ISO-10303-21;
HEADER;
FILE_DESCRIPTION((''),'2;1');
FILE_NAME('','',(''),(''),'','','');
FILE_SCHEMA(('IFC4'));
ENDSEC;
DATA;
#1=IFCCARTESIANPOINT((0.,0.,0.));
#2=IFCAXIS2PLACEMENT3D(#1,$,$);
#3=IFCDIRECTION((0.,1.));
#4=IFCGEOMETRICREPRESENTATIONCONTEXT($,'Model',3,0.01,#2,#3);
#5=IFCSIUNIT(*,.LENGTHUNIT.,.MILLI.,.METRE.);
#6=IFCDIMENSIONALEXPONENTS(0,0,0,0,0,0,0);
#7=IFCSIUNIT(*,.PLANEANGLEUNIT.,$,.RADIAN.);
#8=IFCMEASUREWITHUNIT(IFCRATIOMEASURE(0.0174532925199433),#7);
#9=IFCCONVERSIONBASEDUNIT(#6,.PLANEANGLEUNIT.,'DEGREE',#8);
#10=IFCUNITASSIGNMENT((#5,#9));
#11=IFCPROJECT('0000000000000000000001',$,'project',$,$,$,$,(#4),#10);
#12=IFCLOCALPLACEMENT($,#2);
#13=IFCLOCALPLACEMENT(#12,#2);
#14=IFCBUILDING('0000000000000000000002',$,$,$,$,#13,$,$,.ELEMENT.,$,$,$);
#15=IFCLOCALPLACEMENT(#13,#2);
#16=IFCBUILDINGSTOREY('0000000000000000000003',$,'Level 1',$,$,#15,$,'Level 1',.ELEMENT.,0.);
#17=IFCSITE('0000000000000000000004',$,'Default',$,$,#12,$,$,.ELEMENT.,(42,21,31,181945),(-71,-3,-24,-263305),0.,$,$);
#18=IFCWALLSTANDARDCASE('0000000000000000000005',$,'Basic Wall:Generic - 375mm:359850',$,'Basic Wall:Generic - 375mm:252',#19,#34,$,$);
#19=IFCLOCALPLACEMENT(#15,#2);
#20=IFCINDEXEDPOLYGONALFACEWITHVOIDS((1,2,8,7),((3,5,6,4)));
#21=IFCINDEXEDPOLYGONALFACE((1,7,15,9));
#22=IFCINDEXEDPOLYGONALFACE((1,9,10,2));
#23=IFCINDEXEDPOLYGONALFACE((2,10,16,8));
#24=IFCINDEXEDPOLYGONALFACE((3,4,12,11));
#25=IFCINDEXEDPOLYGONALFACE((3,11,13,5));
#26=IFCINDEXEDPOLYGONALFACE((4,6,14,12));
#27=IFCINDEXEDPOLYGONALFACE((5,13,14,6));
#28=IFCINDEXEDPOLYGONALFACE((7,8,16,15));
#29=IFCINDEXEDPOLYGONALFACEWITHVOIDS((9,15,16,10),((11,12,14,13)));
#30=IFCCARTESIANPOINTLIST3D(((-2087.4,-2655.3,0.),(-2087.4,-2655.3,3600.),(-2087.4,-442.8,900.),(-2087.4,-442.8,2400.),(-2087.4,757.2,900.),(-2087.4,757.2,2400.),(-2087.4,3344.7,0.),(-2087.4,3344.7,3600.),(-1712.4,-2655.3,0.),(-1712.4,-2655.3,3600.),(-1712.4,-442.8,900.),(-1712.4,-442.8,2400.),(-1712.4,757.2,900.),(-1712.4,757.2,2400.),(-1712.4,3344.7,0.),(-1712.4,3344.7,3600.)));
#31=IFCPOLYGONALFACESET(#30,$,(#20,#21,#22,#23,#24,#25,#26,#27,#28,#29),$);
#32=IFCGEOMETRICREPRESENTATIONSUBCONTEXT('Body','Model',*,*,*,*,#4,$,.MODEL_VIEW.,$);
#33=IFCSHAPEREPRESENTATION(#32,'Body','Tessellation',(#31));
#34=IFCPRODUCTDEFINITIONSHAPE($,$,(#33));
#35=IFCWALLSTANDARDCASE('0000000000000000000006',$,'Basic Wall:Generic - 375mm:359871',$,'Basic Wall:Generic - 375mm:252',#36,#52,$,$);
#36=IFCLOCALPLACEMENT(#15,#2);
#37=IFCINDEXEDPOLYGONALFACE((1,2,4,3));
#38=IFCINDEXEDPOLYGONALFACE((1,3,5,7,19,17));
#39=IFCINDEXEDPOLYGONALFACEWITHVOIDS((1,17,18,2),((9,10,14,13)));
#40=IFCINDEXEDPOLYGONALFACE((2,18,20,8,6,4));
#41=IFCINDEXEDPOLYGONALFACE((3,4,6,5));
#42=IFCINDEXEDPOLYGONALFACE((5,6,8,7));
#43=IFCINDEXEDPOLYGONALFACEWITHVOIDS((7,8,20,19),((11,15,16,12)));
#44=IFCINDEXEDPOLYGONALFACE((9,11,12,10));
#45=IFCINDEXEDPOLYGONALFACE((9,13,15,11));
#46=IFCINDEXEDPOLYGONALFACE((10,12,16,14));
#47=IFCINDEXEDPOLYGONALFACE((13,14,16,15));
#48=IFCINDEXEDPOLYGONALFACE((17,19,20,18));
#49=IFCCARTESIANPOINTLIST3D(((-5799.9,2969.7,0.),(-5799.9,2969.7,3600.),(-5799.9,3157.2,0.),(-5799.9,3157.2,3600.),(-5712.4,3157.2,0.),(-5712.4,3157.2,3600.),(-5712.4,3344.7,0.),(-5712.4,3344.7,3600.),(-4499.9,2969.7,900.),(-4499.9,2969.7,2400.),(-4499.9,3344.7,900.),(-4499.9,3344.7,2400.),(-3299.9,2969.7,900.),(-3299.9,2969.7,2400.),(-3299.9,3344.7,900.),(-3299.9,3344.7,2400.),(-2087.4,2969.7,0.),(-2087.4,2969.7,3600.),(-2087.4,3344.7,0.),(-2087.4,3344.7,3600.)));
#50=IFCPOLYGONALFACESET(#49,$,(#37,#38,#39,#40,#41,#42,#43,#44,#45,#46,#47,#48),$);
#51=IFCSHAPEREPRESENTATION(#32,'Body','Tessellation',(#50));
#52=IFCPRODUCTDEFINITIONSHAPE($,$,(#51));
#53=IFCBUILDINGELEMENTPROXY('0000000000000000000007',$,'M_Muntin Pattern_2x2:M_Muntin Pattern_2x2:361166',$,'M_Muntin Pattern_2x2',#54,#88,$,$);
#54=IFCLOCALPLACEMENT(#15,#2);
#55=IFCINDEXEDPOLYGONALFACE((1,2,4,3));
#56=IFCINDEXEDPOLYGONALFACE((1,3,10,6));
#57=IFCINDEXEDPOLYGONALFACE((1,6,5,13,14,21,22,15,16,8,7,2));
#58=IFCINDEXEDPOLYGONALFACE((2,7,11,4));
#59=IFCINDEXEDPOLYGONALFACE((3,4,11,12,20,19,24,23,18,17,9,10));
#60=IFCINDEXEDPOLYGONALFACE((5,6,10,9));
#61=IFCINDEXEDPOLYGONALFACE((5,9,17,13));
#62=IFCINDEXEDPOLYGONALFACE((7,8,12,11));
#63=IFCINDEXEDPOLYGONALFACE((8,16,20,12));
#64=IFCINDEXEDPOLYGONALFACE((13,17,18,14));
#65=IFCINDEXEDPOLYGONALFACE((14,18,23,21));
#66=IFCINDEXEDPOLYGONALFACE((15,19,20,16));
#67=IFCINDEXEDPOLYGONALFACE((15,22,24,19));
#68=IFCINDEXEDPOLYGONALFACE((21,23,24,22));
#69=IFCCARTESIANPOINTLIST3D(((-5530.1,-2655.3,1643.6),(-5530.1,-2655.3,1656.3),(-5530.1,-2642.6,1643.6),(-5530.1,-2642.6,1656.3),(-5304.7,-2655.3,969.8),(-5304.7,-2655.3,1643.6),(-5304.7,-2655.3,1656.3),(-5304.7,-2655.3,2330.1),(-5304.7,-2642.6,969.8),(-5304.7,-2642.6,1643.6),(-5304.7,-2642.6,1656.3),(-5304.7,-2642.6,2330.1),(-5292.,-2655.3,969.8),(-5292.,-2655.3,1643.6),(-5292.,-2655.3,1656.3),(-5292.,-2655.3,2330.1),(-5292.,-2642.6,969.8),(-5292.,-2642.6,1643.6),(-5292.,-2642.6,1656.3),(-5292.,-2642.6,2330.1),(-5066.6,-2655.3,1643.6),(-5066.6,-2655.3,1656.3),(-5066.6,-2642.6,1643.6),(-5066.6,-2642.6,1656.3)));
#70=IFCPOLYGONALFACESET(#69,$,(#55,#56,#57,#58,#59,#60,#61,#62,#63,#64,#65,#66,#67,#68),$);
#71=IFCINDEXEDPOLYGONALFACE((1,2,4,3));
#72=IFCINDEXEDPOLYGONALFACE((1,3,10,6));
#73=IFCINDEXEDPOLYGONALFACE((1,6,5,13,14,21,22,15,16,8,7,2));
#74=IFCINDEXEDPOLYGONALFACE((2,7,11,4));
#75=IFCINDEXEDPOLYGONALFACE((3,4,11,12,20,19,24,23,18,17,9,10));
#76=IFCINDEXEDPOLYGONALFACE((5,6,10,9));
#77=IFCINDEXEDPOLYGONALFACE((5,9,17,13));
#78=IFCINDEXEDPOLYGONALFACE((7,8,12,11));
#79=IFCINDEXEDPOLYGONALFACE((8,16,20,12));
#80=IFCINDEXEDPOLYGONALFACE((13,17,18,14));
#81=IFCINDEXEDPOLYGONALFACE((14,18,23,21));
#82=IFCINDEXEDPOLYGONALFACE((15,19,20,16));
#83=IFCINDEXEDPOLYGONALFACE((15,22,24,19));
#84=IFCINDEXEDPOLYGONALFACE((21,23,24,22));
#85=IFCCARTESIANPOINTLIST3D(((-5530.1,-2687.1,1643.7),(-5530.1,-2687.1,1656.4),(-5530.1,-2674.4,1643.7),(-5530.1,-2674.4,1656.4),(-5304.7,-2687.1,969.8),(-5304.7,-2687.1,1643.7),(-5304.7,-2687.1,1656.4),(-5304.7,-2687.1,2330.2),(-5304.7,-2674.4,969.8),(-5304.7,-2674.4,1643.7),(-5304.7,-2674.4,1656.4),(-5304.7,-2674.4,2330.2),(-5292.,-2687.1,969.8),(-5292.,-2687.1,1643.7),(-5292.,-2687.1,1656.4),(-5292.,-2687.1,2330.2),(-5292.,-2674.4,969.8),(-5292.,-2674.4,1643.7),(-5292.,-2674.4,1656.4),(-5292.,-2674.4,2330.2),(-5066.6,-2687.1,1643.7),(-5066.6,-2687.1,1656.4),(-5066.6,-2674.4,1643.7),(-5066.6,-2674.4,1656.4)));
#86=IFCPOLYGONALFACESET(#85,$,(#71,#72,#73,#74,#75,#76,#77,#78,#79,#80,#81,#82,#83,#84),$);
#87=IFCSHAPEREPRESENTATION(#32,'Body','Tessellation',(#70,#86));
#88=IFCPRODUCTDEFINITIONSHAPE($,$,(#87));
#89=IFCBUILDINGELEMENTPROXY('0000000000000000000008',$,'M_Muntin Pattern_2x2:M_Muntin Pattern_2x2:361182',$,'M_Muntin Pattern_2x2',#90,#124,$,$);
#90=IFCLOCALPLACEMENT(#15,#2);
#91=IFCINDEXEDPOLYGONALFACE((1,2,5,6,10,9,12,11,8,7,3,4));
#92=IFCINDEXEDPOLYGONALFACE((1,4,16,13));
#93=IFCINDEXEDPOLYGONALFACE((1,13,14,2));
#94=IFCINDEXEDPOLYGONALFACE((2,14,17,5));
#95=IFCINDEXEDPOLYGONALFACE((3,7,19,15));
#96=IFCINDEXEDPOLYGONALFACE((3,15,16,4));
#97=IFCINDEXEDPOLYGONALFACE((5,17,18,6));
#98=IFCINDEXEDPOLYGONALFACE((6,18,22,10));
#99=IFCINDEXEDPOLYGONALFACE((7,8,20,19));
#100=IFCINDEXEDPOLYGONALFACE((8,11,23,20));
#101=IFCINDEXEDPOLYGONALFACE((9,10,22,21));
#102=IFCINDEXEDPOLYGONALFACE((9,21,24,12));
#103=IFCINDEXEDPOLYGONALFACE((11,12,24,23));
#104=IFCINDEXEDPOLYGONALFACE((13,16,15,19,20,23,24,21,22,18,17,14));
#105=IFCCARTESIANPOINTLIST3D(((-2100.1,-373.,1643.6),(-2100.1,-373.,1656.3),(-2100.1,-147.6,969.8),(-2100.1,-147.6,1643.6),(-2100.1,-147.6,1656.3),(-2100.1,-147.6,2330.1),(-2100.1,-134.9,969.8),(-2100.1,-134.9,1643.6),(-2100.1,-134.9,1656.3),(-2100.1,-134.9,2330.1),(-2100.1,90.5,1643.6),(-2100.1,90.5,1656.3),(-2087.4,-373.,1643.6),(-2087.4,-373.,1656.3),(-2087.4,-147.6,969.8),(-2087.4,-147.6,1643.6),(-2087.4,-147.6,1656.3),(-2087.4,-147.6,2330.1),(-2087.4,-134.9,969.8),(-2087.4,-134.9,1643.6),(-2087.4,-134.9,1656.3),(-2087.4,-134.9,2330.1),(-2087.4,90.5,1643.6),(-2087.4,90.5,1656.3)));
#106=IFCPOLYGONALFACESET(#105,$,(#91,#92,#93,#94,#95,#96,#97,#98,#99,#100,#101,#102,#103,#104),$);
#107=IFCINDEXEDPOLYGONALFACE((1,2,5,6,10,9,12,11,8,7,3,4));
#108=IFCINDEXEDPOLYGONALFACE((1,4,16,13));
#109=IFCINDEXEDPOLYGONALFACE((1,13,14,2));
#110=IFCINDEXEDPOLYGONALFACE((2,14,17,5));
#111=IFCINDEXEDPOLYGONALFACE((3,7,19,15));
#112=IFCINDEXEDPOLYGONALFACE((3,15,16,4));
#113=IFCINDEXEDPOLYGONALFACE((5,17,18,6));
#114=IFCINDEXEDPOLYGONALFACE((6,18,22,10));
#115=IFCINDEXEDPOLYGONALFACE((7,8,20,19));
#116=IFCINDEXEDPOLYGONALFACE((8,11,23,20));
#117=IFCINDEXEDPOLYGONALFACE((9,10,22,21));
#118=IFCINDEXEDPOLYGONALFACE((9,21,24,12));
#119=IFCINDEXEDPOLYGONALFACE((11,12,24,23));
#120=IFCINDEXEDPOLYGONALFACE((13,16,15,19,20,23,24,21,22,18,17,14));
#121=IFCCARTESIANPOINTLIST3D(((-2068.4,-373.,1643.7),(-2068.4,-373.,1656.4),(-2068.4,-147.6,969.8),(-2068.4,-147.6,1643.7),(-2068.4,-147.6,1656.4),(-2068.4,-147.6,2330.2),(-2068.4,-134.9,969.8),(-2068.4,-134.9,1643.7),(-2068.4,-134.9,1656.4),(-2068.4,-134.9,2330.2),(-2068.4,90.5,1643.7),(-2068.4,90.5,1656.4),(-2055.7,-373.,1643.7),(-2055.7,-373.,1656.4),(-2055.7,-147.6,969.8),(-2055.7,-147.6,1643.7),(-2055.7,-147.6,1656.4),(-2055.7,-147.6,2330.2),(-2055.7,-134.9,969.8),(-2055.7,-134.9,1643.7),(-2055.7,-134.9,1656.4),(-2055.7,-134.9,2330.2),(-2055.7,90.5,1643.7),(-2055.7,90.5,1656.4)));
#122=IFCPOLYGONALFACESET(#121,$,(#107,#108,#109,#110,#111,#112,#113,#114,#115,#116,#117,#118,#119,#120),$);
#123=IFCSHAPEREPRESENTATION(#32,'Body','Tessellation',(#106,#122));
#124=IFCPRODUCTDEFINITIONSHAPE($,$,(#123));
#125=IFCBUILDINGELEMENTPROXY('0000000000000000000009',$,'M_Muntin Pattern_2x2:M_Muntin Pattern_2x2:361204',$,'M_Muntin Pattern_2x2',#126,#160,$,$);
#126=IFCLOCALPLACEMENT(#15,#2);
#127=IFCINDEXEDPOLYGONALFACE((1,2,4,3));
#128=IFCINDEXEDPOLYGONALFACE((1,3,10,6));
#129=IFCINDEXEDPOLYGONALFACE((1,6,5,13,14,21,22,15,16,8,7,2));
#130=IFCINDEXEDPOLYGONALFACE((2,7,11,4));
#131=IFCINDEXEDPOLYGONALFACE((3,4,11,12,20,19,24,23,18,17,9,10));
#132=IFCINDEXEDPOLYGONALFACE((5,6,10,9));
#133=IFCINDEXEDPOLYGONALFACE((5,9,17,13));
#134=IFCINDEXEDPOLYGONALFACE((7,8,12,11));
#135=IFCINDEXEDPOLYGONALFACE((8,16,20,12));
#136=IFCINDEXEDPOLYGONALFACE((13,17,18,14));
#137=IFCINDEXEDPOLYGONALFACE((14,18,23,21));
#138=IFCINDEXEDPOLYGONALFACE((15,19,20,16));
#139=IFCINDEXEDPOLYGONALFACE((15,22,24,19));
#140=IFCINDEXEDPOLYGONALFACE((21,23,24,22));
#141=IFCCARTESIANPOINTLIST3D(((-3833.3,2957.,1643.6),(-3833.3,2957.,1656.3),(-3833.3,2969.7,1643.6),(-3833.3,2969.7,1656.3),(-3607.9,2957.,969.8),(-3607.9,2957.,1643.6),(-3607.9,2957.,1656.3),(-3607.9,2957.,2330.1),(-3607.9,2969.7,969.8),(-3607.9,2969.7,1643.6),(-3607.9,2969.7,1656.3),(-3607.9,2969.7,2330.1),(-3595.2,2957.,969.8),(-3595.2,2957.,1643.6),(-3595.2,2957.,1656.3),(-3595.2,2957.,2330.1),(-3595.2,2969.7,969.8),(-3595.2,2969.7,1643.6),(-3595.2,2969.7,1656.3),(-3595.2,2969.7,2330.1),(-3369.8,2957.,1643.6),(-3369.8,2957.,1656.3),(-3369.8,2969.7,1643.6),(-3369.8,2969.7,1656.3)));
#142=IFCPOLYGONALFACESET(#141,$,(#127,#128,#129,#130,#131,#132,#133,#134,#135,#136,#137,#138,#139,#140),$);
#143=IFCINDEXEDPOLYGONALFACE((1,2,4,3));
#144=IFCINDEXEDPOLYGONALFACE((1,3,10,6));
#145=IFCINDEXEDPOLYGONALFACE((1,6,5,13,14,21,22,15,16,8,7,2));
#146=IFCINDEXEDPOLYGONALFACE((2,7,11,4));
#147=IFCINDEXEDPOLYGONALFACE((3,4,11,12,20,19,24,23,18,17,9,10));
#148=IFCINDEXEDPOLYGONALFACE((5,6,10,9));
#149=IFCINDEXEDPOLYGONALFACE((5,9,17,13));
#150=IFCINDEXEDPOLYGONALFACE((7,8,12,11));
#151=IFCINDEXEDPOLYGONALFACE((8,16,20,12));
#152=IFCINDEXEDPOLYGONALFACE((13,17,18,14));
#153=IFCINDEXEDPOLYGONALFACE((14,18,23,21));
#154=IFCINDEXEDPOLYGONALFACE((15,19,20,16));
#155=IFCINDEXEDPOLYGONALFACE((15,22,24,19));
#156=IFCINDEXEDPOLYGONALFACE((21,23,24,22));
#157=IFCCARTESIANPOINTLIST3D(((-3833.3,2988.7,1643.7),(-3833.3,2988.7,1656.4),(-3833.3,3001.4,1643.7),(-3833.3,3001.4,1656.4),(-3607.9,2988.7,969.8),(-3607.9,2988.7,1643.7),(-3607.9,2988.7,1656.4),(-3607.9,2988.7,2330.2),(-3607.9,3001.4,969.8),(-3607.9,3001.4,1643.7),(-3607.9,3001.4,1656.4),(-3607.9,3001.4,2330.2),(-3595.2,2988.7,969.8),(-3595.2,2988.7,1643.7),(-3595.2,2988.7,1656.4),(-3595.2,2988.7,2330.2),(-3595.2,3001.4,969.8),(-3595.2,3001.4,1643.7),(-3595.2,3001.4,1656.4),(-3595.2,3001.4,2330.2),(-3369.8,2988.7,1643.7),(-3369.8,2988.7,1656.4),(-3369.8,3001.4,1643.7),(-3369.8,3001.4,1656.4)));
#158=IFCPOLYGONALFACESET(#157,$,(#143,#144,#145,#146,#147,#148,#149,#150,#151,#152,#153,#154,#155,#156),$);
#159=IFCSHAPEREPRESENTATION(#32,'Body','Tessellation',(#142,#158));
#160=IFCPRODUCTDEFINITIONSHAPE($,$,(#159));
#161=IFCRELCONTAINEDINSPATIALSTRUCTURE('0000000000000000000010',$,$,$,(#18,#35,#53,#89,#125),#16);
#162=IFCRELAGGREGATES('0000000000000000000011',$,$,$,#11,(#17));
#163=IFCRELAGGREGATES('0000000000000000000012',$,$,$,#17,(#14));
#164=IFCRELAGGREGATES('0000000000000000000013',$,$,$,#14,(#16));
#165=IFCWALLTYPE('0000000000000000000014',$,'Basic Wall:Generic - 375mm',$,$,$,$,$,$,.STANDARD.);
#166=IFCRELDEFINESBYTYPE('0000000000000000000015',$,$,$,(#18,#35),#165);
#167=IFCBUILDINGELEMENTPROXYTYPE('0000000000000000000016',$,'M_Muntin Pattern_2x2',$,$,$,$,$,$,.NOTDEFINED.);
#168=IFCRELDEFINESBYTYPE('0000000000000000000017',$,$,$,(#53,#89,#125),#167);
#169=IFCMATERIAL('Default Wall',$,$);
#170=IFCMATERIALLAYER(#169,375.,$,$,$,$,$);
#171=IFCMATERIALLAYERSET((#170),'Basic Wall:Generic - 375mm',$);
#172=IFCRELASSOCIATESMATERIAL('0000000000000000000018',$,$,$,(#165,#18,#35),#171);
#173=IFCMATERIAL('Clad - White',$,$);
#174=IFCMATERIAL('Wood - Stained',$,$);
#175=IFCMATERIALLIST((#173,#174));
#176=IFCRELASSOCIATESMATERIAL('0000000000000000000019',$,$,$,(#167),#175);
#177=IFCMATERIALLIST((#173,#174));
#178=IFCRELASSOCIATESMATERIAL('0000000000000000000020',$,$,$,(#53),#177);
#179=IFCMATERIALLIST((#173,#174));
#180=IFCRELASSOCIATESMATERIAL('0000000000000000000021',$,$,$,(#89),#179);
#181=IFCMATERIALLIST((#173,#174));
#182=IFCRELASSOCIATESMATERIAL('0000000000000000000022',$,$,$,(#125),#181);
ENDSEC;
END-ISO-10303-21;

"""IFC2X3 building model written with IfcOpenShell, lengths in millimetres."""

from ifc_helpers import new_model, entity, si_unit, converted_unit, direction, frame, frame_2d, origin, place, context, subcontext, project, spatial, polyline, rectangle, outline, extrude, clip, bounded_halfspace, source, transform, mapped, material, material_list, layer, layer_set, layer_usage, type_object, type_shapes, element, save


model = new_model("IFC2X3")

# Units and contexts
model_context = context("Model", 3, precision=0.01, world=origin(), true_north=direction((0.0, 1.0)))
body_context = subcontext(model_context, "Body", "Model", "MODEL_VIEW")
ifc_project = project(units=[si_unit("LENGTHUNIT", "METRE", prefix="MILLI"), converted_unit("PLANEANGLEUNIT", "DEGREE", entity("IfcRatioMeasure", 0.0174532925199433), si_unit("PLANEANGLEUNIT", "RADIAN"), dimensions=[0, 0, 0, 0, 0, 0, 0])], contexts=[model_context])

# Site, building, storey
site_placement = place(None, origin())
site = spatial("IfcSite", under=ifc_project, at=site_placement, Name="Default", CompositionType="ELEMENT", RefLatitude=(42, 21, 31, 181945), RefLongitude=(-71, -3, -24, -263305), RefElevation=0.0)
building_placement = place(site_placement, origin())
building = spatial("IfcBuilding", under=site, at=building_placement, CompositionType="ELEMENT")
storey_placement = place(building_placement, origin())
storey = spatial("IfcBuildingStorey", under=building, at=storey_placement, Name="Level 1", LongName="Level 1", CompositionType="ELEMENT", Elevation=0.0)

# Walls, openings
ifc_material_1 = material(Name="Default Wall")
ifc_layer = layer(ifc_material_1, 375.0)
ifc_layer_set = layer_set([ifc_layer], Name="Basic Wall:Generic - 375mm")
ifc_layer_usage_1 = layer_usage(ifc_layer_set, "AXIS2", "NEGATIVE", 187.5)
wall_type = type_object("IfcWallType", Name="Basic Wall:Generic - 375mm", PredefinedType="STANDARD", material=ifc_layer_set)
wall_1_placement = place(storey_placement, frame((-1899.9, -2655.3, 0.0), z_axis=(0.0, 0.0, 1.0), x_axis=(0.0, 1.0, 0.0)))
wall_1 = element("IfcWallStandardCase", 1, at=wall_1_placement, inside=storey, type_object=wall_type, material=ifc_layer_usage_1, Name="Basic Wall:Generic - 375mm:359850", ObjectType="Basic Wall:Generic - 375mm:252", context=body_context, shape_type="Clipping", body=[
    clip(extrude(rectangle(XDim=6000.0, YDim=375.0, at=frame_2d((3000.0, 0.0), x_axis=(-1.0, 0.0))), origin(), (0.0, 0.0, 1.0), 3600.0), bounded_halfspace(frame((0.0, -187.5, 3600.0), z_axis=(0.0, 0.0, -1.0), x_axis=(0.0, -1.0, 0.0)), True, frame((0.0, -187.5, 3600.0)), polyline([(0.0, 0.0), (6000.0, 0.0), (6000.0, 375.0), (5625.0, 375.0), (0.0, 375.0), (0.0, 0.0)]))),
])
opening_1_placement = place(wall_1_placement, frame((2212.5, -187.5, 900.0)))
element("IfcOpeningElement", 2, at=opening_1_placement, cuts=wall_1, ObjectType="Opening", context=body_context, shape_type="SweptSolid", body=[
    extrude(rectangle(XDim=1500.0, YDim=1200.0, at=frame_2d((750.0, 600.0), x_axis=(-1.0, 0.0))), frame((0.0, 0.0, 0.0), z_axis=(0.0, 1.0, 0.0), x_axis=(0.0, 0.0, 1.0)), (0.0, 0.0, 1.0), 375.0),
])
ifc_layer_usage_2 = layer_usage(ifc_layer_set, "AXIS2", "NEGATIVE", 187.5)
wall_2_placement = place(storey_placement, frame((-2087.4, 3157.2, 0.0), z_axis=(0.0, 0.0, 1.0), x_axis=(-1.0, 0.0, 0.0)))
wall_2 = element("IfcWallStandardCase", 3, at=wall_2_placement, inside=storey, type_object=wall_type, material=ifc_layer_usage_2, Name="Basic Wall:Generic - 375mm:359871", ObjectType="Basic Wall:Generic - 375mm:252", context=body_context, shape_type="Clipping", body=[
    clip(extrude(outline(polyline([(3625.0, -187.5), (3625.0, 0.0), (3712.5, 0.0), (3712.5, 187.5), (0.0, 187.5), (0.0, -187.5), (3625.0, -187.5)])), origin(), (0.0, 0.0, 1.0), 3600.0), bounded_halfspace(frame((0.0, -187.5, 3600.0), z_axis=(0.0, 0.0, -1.0), x_axis=(-1.0, 0.0, 0.0)), True, frame((0.0, -187.5, 3600.0)), polyline([(0.0, 0.0), (3625.0, 0.0), (3625.0, 187.5), (3712.5, 187.5), (3712.5, 375.0), (0.0, 375.0), (0.0, 0.0)]))),
])
opening_2_placement = place(wall_2_placement, frame((1212.5, -187.5, 900.0)))
element("IfcOpeningElement", 4, at=opening_2_placement, cuts=wall_2, ObjectType="Opening", context=body_context, shape_type="SweptSolid", body=[
    extrude(rectangle(XDim=1500.0, YDim=1200.0, at=frame_2d((750.0, 600.0), x_axis=(-1.0, 0.0))), frame((0.0, 0.0, 0.0), z_axis=(0.0, 1.0, 0.0), x_axis=(0.0, 0.0, 1.0)), (0.0, 0.0, 1.0), 375.0),
])

# Building element proxies
ifc_material_2 = material(Name="Clad - White")
ifc_material_3 = material(Name="Wood - Stained")
ifc_material_list_1 = material_list([ifc_material_2, ifc_material_3])
ifc_material_list_2 = material_list([ifc_material_2, ifc_material_3])
building_element_proxy_type_1 = type_object("IfcBuildingElementProxyType", Name="M_Muntin Pattern_2x2", PredefinedType="NOTDEFINED", material=ifc_material_list_2)
shared_shape_1 = source(origin(), body_context, "Body", "SweptSolid", [
    extrude(outline(polyline([(6.4, -6.4), (680.1, -6.4), (680.1, 6.3), (6.4, 6.3), (6.4, 231.7), (-6.3, 231.7), (-6.3, 6.3), (-680.2, 6.3), (-680.2, -6.4), (-6.3, -6.4), (-6.3, -231.7), (6.4, -231.7), (6.4, -6.4)])), frame((0.0, 9.5, 680.1), z_axis=(0.0, 1.0, 0.0), x_axis=(0.0, 0.0, 1.0)), (0.0, 0.0, 1.0), 12.7),
    extrude(outline(polyline([(6.4, -6.4), (680.2, -6.4), (680.2, 6.3), (6.4, 6.3), (6.4, 231.7), (-6.3, 231.7), (-6.3, 6.3), (-680.2, 6.3), (-680.2, -6.4), (-6.3, -6.4), (-6.3, -231.7), (6.4, -231.7), (6.4, -6.4)])), frame((0.0, -22.2, 680.2), z_axis=(0.0, 1.0, 0.0), x_axis=(0.0, 0.0, 1.0)), (0.0, 0.0, 1.0), 12.7),
])
type_shapes(building_element_proxy_type_1, [shared_shape_1])
proxy_1_placement = place(storey_placement, frame((-5298.4, -2664.9, 969.8)))
element("IfcBuildingElementProxy", 5, at=proxy_1_placement, inside=storey, type_object=building_element_proxy_type_1, material=ifc_material_list_1, Name="M_Muntin Pattern_2x2:M_Muntin Pattern_2x2:361166", ObjectType="M_Muntin Pattern_2x2", context=body_context, shape_type="MappedRepresentation", body=[
    mapped(shared_shape_1, transform((0.0, 0.0, 0.0), scale=1.0)),
])
ifc_material_list_3 = material_list([ifc_material_2, ifc_material_3])
proxy_2_placement = place(storey_placement, frame((-2077.9, -141.3, 969.8), z_axis=(0.0, 0.0, 1.0), x_axis=(0.0, 1.0, 0.0)))
element("IfcBuildingElementProxy", 6, at=proxy_2_placement, inside=storey, type_object=building_element_proxy_type_1, material=ifc_material_list_3, Name="M_Muntin Pattern_2x2:M_Muntin Pattern_2x2:361182", ObjectType="M_Muntin Pattern_2x2", context=body_context, shape_type="MappedRepresentation", body=[
    mapped(shared_shape_1, transform((0.0, 0.0, 0.0), scale=1.0)),
])
ifc_material_list_4 = material_list([ifc_material_2, ifc_material_3])
proxy_3_placement = place(storey_placement, frame((-3601.5, 2979.2, 969.8), z_axis=(0.0, 0.0, 1.0), x_axis=(-1.0, 0.0, 0.0)))
element("IfcBuildingElementProxy", 7, at=proxy_3_placement, inside=storey, type_object=building_element_proxy_type_1, material=ifc_material_list_4, Name="M_Muntin Pattern_2x2:M_Muntin Pattern_2x2:361204", ObjectType="M_Muntin Pattern_2x2", context=body_context, shape_type="MappedRepresentation", body=[
    mapped(shared_shape_1, transform((0.0, 0.0, 0.0), scale=1.0)),
])

save(model, "model.ifc")
